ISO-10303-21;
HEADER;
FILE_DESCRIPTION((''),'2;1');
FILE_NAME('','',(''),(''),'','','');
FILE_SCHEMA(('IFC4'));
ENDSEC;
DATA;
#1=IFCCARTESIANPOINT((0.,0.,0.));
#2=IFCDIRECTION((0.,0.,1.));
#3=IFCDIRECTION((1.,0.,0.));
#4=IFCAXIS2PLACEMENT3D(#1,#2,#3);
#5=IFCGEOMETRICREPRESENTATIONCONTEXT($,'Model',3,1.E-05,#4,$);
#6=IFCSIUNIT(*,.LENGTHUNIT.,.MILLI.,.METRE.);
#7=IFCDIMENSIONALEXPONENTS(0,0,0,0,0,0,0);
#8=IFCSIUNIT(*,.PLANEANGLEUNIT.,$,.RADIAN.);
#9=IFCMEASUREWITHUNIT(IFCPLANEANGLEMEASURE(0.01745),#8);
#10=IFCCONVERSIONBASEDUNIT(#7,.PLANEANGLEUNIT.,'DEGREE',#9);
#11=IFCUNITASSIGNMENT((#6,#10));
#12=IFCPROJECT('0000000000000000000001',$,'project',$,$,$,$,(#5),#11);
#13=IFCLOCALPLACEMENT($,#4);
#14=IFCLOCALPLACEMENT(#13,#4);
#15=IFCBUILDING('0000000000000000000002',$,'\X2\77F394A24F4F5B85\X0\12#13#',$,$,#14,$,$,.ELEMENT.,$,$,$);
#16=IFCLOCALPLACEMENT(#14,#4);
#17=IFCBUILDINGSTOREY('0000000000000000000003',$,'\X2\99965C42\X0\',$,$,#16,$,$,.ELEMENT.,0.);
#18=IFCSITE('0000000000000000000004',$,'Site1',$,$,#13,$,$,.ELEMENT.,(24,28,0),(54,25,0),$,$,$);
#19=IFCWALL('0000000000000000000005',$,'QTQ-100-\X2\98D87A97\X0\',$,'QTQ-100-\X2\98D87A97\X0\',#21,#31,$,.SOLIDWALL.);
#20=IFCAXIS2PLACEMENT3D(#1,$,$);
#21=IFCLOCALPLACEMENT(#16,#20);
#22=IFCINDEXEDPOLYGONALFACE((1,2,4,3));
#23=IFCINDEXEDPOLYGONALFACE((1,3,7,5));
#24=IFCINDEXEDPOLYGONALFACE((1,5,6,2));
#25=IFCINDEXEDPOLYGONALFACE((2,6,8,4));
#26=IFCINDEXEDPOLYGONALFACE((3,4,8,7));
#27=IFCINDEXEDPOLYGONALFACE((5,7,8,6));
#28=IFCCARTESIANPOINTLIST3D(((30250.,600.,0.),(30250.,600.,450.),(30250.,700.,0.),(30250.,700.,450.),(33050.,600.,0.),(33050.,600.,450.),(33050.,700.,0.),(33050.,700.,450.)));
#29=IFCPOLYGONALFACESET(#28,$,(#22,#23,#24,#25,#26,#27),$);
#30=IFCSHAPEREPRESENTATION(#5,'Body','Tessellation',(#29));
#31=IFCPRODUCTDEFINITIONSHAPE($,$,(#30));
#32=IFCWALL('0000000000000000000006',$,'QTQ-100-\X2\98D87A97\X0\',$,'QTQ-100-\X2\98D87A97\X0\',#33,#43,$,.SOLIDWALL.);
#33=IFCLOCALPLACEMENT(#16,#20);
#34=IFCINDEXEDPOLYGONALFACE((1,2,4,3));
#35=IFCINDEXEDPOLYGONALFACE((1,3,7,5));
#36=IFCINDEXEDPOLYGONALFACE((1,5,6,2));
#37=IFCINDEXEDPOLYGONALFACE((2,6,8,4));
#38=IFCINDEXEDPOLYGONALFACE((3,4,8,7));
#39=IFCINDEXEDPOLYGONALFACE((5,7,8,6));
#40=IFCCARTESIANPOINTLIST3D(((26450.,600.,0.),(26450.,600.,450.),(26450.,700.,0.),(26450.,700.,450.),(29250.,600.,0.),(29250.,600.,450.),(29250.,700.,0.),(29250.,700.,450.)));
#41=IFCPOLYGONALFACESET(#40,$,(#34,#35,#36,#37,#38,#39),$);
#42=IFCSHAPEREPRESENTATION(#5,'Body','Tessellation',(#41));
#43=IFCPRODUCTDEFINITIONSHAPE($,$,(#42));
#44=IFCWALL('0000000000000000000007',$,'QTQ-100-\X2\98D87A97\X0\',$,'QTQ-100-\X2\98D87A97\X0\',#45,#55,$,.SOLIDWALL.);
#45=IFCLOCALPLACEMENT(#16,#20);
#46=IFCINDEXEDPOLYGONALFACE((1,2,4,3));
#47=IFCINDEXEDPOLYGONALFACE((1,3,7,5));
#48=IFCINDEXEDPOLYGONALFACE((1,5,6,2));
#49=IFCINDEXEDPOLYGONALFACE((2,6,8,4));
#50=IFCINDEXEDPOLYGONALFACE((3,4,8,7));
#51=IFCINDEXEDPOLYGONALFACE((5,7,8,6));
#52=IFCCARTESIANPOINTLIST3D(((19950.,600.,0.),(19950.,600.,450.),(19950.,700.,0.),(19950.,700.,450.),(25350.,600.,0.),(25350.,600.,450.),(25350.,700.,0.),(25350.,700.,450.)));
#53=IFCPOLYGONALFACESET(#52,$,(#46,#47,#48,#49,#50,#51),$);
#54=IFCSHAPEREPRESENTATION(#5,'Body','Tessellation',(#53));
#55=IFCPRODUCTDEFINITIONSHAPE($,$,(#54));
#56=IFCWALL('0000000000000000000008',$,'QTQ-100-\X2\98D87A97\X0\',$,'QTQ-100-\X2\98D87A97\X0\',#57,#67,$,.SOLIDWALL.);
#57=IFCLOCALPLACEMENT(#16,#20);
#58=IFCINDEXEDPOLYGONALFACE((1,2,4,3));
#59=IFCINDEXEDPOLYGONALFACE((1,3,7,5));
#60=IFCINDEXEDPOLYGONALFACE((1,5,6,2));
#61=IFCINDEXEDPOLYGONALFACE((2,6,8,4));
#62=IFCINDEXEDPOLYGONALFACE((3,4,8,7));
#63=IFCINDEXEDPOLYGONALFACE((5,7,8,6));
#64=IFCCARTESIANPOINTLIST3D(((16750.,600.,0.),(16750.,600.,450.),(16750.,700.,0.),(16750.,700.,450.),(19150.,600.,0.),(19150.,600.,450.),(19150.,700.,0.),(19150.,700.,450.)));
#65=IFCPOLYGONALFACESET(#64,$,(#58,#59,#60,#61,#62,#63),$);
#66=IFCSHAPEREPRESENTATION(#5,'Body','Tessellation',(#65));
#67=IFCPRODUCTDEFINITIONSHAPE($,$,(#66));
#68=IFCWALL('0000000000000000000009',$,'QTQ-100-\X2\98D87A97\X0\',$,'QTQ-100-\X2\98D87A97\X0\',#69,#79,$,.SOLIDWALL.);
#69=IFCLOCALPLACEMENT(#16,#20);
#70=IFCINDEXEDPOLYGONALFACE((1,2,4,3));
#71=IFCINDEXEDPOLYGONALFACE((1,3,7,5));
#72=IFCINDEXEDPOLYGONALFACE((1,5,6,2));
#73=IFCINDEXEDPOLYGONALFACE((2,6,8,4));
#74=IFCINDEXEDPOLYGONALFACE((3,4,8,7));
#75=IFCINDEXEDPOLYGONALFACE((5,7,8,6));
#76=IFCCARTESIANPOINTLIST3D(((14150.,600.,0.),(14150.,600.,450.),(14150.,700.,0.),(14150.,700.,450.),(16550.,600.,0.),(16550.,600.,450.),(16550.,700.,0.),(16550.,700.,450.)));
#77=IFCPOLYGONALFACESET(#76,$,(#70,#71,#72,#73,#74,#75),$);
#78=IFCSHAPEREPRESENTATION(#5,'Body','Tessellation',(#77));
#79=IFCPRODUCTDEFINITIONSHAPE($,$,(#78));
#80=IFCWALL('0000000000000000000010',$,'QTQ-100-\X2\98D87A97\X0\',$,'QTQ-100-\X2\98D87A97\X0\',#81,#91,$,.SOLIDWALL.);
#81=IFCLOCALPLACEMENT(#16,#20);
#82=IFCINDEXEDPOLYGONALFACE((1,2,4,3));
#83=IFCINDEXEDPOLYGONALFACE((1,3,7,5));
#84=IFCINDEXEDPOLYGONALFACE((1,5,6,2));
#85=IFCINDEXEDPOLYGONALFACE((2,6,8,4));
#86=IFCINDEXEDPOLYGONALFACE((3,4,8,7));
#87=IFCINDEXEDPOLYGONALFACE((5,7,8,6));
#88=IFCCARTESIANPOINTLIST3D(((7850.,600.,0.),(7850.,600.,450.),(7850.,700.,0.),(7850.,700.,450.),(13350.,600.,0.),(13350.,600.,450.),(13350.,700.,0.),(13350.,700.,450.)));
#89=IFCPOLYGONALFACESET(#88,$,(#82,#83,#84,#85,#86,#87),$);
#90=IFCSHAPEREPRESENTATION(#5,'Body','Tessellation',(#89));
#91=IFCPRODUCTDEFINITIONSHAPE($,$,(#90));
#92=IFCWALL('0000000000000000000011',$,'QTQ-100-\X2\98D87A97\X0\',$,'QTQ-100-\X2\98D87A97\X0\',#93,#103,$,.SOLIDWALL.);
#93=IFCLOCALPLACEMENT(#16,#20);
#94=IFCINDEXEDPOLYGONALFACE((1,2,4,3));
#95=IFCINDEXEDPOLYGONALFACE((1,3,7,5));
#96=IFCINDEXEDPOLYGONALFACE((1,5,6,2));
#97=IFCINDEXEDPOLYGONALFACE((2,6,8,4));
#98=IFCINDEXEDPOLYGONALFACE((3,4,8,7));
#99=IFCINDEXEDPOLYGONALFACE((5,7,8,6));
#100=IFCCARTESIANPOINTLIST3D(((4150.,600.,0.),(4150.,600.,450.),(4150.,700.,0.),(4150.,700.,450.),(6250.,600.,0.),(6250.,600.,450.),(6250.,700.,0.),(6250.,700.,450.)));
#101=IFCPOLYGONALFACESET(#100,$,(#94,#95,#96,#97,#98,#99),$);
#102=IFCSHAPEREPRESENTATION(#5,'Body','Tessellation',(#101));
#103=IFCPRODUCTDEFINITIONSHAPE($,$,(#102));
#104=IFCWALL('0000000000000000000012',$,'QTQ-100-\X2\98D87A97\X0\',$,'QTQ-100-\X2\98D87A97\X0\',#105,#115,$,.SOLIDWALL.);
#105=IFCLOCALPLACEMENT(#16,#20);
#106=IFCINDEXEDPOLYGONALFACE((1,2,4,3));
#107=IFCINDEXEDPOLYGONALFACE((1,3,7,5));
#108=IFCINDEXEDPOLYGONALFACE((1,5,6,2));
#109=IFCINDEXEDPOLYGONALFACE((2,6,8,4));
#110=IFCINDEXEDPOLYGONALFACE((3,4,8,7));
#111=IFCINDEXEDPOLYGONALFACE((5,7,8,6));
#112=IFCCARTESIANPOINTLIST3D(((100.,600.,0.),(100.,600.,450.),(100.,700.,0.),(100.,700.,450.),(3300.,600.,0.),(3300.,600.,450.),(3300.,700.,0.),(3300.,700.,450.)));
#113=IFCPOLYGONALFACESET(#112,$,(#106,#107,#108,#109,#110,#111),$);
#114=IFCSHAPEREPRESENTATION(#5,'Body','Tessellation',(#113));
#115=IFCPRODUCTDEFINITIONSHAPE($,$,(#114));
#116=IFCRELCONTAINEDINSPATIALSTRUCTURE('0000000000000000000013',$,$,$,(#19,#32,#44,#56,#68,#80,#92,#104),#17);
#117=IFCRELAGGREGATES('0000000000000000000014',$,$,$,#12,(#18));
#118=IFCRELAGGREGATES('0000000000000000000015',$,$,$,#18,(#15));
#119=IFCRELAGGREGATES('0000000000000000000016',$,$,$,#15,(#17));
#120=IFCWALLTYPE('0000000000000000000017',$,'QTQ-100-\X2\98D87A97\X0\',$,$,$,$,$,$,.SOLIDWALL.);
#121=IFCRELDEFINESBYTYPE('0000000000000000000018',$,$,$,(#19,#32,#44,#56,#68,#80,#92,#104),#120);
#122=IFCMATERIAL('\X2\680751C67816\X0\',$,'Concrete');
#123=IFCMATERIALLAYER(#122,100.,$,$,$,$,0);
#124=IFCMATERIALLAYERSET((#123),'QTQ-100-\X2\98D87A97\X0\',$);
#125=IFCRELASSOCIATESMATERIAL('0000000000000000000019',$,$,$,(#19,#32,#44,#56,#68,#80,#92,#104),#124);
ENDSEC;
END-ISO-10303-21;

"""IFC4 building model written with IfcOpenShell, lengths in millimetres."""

from ifc_helpers import new_model, entity, si_unit, converted_unit, frame, origin_with_axes, place, context, project, spatial, polyline, outline, extrude, material, layer, layer_set, type_object, element, save


model = new_model("IFC4")

# Units and contexts
model_context = context("Model", 3, precision=1e-05, world=origin_with_axes())
ifc_project = project(units=[si_unit("LENGTHUNIT", "METRE", prefix="MILLI"), converted_unit("PLANEANGLEUNIT", "DEGREE", entity("IfcPlaneAngleMeasure", 0.01745), si_unit("PLANEANGLEUNIT", "RADIAN"), dimensions=[0, 0, 0, 0, 0, 0, 0])], contexts=[model_context])

# Site, building, storey
site_placement = place(None, origin_with_axes())
site = spatial("IfcSite", under=ifc_project, at=site_placement, Name="Site1", CompositionType="ELEMENT", RefLatitude=(24, 28, 0), RefLongitude=(54, 25, 0))
building_placement = place(site_placement, origin_with_axes())
building = spatial("IfcBuilding", under=site, at=building_placement, Name="石钢住宅12#13#", CompositionType="ELEMENT")
storey_placement = place(building_placement, origin_with_axes())
storey = spatial("IfcBuildingStorey", under=building, at=storey_placement, Name="首层", CompositionType="ELEMENT", Elevation=0.0)

# Walls
ifc_material_1 = material(Name="标准砖", Category="Concrete")
ifc_layer_1 = layer(ifc_material_1, 100.0, Priority=0)
ifc_layer_set_1 = layer_set([ifc_layer_1], Name="QTQ-100-飘窗")
wall_type_1 = type_object("IfcWallType", Name="QTQ-100-飘窗", PredefinedType="SOLIDWALL")
wall_1_placement = place(storey_placement, origin_with_axes())
element("IfcWall", 1, at=wall_1_placement, inside=storey, type_object=wall_type_1, material=ifc_layer_set_1, Name="QTQ-100-飘窗", ObjectType="QTQ-100-飘窗", PredefinedType="SOLIDWALL", context=model_context, shape_type="SweptSolid", body=[
    extrude(outline(polyline([(0.0, 0.0), (450.0, 0.0), (450.0, 2800.0), (0.0, 2800.0), (0.0, 0.0)])), frame((33050.0, 600.0, 450.0), z_axis=(0.0, 1.0, 0.0), x_axis=(0.0, 0.0, -1.0)), (0.0, 0.0, 1.0), 100.0),
])
wall_2_placement = place(storey_placement, origin_with_axes())
element("IfcWall", 2, at=wall_2_placement, inside=storey, type_object=wall_type_1, material=ifc_layer_set_1, Name="QTQ-100-飘窗", ObjectType="QTQ-100-飘窗", PredefinedType="SOLIDWALL", context=model_context, shape_type="SweptSolid", body=[
    extrude(outline(polyline([(0.0, 0.0), (450.0, 0.0), (450.0, 2800.0), (0.0, 2800.0), (0.0, 0.0)])), frame((26450.0, 700.0, 450.0), z_axis=(0.0, -1.0, 0.0), x_axis=(0.0, 0.0, -1.0)), (0.0, 0.0, 1.0), 100.0),
])
wall_3_placement = place(storey_placement, origin_with_axes())
element("IfcWall", 3, at=wall_3_placement, inside=storey, type_object=wall_type_1, material=ifc_layer_set_1, Name="QTQ-100-飘窗", ObjectType="QTQ-100-飘窗", PredefinedType="SOLIDWALL", context=model_context, shape_type="SweptSolid", body=[
    extrude(outline(polyline([(0.0, 0.0), (450.0, 0.0), (450.0, 5400.0), (0.0, 5400.0), (0.0, 0.0)])), frame((19950.0, 700.0, 450.0), z_axis=(0.0, -1.0, 0.0), x_axis=(0.0, 0.0, -1.0)), (0.0, 0.0, 1.0), 100.0),
])
wall_4_placement = place(storey_placement, origin_with_axes())
element("IfcWall", 4, at=wall_4_placement, inside=storey, type_object=wall_type_1, material=ifc_layer_set_1, Name="QTQ-100-飘窗", ObjectType="QTQ-100-飘窗", PredefinedType="SOLIDWALL", context=model_context, shape_type="SweptSolid", body=[
    extrude(outline(polyline([(0.0, 0.0), (450.0, 0.0), (450.0, 2400.0), (0.0, 2400.0), (0.0, 0.0)])), frame((16750.0, 700.0, 450.0), z_axis=(0.0, -1.0, 0.0), x_axis=(0.0, 0.0, -1.0)), (0.0, 0.0, 1.0), 100.0),
])
wall_5_placement = place(storey_placement, origin_with_axes())
element("IfcWall", 5, at=wall_5_placement, inside=storey, type_object=wall_type_1, material=ifc_layer_set_1, Name="QTQ-100-飘窗", ObjectType="QTQ-100-飘窗", PredefinedType="SOLIDWALL", context=model_context, shape_type="SweptSolid", body=[
    extrude(outline(polyline([(0.0, 0.0), (450.0, 0.0), (450.0, 2400.0), (0.0, 2400.0), (0.0, 0.0)])), frame((14150.0, 700.0, 450.0), z_axis=(0.0, -1.0, 0.0), x_axis=(0.0, 0.0, -1.0)), (0.0, 0.0, 1.0), 100.0),
])
wall_6_placement = place(storey_placement, origin_with_axes())
element("IfcWall", 6, at=wall_6_placement, inside=storey, type_object=wall_type_1, material=ifc_layer_set_1, Name="QTQ-100-飘窗", ObjectType="QTQ-100-飘窗", PredefinedType="SOLIDWALL", context=model_context, shape_type="SweptSolid", body=[
    extrude(outline(polyline([(0.0, 0.0), (450.0, 0.0), (450.0, 5500.0), (0.0, 5500.0), (0.0, 0.0)])), frame((7850.0, 700.0, 450.0), z_axis=(0.0, -1.0, 0.0), x_axis=(0.0, 0.0, -1.0)), (0.0, 0.0, 1.0), 100.0),
])
wall_7_placement = place(storey_placement, origin_with_axes())
element("IfcWall", 7, at=wall_7_placement, inside=storey, type_object=wall_type_1, material=ifc_layer_set_1, Name="QTQ-100-飘窗", ObjectType="QTQ-100-飘窗", PredefinedType="SOLIDWALL", context=model_context, shape_type="SweptSolid", body=[
    extrude(outline(polyline([(0.0, 0.0), (450.0, 0.0), (450.0, 2100.0), (0.0, 2100.0), (0.0, 0.0)])), frame((4150.0, 700.0, 450.0), z_axis=(0.0, -1.0, 0.0), x_axis=(0.0, 0.0, -1.0)), (0.0, 0.0, 1.0), 100.0),
])
wall_8_placement = place(storey_placement, origin_with_axes())
element("IfcWall", 8, at=wall_8_placement, inside=storey, type_object=wall_type_1, material=ifc_layer_set_1, Name="QTQ-100-飘窗", ObjectType="QTQ-100-飘窗", PredefinedType="SOLIDWALL", context=model_context, shape_type="SweptSolid", body=[
    extrude(outline(polyline([(0.0, 0.0), (450.0, 0.0), (450.0, 3200.0), (0.0, 3200.0), (0.0, 0.0)])), frame((100.0, 700.0, 450.0), z_axis=(0.0, -1.0, 0.0), x_axis=(0.0, 0.0, -1.0)), (0.0, 0.0, 1.0), 100.0),
])

save(model, "model.ifc")
